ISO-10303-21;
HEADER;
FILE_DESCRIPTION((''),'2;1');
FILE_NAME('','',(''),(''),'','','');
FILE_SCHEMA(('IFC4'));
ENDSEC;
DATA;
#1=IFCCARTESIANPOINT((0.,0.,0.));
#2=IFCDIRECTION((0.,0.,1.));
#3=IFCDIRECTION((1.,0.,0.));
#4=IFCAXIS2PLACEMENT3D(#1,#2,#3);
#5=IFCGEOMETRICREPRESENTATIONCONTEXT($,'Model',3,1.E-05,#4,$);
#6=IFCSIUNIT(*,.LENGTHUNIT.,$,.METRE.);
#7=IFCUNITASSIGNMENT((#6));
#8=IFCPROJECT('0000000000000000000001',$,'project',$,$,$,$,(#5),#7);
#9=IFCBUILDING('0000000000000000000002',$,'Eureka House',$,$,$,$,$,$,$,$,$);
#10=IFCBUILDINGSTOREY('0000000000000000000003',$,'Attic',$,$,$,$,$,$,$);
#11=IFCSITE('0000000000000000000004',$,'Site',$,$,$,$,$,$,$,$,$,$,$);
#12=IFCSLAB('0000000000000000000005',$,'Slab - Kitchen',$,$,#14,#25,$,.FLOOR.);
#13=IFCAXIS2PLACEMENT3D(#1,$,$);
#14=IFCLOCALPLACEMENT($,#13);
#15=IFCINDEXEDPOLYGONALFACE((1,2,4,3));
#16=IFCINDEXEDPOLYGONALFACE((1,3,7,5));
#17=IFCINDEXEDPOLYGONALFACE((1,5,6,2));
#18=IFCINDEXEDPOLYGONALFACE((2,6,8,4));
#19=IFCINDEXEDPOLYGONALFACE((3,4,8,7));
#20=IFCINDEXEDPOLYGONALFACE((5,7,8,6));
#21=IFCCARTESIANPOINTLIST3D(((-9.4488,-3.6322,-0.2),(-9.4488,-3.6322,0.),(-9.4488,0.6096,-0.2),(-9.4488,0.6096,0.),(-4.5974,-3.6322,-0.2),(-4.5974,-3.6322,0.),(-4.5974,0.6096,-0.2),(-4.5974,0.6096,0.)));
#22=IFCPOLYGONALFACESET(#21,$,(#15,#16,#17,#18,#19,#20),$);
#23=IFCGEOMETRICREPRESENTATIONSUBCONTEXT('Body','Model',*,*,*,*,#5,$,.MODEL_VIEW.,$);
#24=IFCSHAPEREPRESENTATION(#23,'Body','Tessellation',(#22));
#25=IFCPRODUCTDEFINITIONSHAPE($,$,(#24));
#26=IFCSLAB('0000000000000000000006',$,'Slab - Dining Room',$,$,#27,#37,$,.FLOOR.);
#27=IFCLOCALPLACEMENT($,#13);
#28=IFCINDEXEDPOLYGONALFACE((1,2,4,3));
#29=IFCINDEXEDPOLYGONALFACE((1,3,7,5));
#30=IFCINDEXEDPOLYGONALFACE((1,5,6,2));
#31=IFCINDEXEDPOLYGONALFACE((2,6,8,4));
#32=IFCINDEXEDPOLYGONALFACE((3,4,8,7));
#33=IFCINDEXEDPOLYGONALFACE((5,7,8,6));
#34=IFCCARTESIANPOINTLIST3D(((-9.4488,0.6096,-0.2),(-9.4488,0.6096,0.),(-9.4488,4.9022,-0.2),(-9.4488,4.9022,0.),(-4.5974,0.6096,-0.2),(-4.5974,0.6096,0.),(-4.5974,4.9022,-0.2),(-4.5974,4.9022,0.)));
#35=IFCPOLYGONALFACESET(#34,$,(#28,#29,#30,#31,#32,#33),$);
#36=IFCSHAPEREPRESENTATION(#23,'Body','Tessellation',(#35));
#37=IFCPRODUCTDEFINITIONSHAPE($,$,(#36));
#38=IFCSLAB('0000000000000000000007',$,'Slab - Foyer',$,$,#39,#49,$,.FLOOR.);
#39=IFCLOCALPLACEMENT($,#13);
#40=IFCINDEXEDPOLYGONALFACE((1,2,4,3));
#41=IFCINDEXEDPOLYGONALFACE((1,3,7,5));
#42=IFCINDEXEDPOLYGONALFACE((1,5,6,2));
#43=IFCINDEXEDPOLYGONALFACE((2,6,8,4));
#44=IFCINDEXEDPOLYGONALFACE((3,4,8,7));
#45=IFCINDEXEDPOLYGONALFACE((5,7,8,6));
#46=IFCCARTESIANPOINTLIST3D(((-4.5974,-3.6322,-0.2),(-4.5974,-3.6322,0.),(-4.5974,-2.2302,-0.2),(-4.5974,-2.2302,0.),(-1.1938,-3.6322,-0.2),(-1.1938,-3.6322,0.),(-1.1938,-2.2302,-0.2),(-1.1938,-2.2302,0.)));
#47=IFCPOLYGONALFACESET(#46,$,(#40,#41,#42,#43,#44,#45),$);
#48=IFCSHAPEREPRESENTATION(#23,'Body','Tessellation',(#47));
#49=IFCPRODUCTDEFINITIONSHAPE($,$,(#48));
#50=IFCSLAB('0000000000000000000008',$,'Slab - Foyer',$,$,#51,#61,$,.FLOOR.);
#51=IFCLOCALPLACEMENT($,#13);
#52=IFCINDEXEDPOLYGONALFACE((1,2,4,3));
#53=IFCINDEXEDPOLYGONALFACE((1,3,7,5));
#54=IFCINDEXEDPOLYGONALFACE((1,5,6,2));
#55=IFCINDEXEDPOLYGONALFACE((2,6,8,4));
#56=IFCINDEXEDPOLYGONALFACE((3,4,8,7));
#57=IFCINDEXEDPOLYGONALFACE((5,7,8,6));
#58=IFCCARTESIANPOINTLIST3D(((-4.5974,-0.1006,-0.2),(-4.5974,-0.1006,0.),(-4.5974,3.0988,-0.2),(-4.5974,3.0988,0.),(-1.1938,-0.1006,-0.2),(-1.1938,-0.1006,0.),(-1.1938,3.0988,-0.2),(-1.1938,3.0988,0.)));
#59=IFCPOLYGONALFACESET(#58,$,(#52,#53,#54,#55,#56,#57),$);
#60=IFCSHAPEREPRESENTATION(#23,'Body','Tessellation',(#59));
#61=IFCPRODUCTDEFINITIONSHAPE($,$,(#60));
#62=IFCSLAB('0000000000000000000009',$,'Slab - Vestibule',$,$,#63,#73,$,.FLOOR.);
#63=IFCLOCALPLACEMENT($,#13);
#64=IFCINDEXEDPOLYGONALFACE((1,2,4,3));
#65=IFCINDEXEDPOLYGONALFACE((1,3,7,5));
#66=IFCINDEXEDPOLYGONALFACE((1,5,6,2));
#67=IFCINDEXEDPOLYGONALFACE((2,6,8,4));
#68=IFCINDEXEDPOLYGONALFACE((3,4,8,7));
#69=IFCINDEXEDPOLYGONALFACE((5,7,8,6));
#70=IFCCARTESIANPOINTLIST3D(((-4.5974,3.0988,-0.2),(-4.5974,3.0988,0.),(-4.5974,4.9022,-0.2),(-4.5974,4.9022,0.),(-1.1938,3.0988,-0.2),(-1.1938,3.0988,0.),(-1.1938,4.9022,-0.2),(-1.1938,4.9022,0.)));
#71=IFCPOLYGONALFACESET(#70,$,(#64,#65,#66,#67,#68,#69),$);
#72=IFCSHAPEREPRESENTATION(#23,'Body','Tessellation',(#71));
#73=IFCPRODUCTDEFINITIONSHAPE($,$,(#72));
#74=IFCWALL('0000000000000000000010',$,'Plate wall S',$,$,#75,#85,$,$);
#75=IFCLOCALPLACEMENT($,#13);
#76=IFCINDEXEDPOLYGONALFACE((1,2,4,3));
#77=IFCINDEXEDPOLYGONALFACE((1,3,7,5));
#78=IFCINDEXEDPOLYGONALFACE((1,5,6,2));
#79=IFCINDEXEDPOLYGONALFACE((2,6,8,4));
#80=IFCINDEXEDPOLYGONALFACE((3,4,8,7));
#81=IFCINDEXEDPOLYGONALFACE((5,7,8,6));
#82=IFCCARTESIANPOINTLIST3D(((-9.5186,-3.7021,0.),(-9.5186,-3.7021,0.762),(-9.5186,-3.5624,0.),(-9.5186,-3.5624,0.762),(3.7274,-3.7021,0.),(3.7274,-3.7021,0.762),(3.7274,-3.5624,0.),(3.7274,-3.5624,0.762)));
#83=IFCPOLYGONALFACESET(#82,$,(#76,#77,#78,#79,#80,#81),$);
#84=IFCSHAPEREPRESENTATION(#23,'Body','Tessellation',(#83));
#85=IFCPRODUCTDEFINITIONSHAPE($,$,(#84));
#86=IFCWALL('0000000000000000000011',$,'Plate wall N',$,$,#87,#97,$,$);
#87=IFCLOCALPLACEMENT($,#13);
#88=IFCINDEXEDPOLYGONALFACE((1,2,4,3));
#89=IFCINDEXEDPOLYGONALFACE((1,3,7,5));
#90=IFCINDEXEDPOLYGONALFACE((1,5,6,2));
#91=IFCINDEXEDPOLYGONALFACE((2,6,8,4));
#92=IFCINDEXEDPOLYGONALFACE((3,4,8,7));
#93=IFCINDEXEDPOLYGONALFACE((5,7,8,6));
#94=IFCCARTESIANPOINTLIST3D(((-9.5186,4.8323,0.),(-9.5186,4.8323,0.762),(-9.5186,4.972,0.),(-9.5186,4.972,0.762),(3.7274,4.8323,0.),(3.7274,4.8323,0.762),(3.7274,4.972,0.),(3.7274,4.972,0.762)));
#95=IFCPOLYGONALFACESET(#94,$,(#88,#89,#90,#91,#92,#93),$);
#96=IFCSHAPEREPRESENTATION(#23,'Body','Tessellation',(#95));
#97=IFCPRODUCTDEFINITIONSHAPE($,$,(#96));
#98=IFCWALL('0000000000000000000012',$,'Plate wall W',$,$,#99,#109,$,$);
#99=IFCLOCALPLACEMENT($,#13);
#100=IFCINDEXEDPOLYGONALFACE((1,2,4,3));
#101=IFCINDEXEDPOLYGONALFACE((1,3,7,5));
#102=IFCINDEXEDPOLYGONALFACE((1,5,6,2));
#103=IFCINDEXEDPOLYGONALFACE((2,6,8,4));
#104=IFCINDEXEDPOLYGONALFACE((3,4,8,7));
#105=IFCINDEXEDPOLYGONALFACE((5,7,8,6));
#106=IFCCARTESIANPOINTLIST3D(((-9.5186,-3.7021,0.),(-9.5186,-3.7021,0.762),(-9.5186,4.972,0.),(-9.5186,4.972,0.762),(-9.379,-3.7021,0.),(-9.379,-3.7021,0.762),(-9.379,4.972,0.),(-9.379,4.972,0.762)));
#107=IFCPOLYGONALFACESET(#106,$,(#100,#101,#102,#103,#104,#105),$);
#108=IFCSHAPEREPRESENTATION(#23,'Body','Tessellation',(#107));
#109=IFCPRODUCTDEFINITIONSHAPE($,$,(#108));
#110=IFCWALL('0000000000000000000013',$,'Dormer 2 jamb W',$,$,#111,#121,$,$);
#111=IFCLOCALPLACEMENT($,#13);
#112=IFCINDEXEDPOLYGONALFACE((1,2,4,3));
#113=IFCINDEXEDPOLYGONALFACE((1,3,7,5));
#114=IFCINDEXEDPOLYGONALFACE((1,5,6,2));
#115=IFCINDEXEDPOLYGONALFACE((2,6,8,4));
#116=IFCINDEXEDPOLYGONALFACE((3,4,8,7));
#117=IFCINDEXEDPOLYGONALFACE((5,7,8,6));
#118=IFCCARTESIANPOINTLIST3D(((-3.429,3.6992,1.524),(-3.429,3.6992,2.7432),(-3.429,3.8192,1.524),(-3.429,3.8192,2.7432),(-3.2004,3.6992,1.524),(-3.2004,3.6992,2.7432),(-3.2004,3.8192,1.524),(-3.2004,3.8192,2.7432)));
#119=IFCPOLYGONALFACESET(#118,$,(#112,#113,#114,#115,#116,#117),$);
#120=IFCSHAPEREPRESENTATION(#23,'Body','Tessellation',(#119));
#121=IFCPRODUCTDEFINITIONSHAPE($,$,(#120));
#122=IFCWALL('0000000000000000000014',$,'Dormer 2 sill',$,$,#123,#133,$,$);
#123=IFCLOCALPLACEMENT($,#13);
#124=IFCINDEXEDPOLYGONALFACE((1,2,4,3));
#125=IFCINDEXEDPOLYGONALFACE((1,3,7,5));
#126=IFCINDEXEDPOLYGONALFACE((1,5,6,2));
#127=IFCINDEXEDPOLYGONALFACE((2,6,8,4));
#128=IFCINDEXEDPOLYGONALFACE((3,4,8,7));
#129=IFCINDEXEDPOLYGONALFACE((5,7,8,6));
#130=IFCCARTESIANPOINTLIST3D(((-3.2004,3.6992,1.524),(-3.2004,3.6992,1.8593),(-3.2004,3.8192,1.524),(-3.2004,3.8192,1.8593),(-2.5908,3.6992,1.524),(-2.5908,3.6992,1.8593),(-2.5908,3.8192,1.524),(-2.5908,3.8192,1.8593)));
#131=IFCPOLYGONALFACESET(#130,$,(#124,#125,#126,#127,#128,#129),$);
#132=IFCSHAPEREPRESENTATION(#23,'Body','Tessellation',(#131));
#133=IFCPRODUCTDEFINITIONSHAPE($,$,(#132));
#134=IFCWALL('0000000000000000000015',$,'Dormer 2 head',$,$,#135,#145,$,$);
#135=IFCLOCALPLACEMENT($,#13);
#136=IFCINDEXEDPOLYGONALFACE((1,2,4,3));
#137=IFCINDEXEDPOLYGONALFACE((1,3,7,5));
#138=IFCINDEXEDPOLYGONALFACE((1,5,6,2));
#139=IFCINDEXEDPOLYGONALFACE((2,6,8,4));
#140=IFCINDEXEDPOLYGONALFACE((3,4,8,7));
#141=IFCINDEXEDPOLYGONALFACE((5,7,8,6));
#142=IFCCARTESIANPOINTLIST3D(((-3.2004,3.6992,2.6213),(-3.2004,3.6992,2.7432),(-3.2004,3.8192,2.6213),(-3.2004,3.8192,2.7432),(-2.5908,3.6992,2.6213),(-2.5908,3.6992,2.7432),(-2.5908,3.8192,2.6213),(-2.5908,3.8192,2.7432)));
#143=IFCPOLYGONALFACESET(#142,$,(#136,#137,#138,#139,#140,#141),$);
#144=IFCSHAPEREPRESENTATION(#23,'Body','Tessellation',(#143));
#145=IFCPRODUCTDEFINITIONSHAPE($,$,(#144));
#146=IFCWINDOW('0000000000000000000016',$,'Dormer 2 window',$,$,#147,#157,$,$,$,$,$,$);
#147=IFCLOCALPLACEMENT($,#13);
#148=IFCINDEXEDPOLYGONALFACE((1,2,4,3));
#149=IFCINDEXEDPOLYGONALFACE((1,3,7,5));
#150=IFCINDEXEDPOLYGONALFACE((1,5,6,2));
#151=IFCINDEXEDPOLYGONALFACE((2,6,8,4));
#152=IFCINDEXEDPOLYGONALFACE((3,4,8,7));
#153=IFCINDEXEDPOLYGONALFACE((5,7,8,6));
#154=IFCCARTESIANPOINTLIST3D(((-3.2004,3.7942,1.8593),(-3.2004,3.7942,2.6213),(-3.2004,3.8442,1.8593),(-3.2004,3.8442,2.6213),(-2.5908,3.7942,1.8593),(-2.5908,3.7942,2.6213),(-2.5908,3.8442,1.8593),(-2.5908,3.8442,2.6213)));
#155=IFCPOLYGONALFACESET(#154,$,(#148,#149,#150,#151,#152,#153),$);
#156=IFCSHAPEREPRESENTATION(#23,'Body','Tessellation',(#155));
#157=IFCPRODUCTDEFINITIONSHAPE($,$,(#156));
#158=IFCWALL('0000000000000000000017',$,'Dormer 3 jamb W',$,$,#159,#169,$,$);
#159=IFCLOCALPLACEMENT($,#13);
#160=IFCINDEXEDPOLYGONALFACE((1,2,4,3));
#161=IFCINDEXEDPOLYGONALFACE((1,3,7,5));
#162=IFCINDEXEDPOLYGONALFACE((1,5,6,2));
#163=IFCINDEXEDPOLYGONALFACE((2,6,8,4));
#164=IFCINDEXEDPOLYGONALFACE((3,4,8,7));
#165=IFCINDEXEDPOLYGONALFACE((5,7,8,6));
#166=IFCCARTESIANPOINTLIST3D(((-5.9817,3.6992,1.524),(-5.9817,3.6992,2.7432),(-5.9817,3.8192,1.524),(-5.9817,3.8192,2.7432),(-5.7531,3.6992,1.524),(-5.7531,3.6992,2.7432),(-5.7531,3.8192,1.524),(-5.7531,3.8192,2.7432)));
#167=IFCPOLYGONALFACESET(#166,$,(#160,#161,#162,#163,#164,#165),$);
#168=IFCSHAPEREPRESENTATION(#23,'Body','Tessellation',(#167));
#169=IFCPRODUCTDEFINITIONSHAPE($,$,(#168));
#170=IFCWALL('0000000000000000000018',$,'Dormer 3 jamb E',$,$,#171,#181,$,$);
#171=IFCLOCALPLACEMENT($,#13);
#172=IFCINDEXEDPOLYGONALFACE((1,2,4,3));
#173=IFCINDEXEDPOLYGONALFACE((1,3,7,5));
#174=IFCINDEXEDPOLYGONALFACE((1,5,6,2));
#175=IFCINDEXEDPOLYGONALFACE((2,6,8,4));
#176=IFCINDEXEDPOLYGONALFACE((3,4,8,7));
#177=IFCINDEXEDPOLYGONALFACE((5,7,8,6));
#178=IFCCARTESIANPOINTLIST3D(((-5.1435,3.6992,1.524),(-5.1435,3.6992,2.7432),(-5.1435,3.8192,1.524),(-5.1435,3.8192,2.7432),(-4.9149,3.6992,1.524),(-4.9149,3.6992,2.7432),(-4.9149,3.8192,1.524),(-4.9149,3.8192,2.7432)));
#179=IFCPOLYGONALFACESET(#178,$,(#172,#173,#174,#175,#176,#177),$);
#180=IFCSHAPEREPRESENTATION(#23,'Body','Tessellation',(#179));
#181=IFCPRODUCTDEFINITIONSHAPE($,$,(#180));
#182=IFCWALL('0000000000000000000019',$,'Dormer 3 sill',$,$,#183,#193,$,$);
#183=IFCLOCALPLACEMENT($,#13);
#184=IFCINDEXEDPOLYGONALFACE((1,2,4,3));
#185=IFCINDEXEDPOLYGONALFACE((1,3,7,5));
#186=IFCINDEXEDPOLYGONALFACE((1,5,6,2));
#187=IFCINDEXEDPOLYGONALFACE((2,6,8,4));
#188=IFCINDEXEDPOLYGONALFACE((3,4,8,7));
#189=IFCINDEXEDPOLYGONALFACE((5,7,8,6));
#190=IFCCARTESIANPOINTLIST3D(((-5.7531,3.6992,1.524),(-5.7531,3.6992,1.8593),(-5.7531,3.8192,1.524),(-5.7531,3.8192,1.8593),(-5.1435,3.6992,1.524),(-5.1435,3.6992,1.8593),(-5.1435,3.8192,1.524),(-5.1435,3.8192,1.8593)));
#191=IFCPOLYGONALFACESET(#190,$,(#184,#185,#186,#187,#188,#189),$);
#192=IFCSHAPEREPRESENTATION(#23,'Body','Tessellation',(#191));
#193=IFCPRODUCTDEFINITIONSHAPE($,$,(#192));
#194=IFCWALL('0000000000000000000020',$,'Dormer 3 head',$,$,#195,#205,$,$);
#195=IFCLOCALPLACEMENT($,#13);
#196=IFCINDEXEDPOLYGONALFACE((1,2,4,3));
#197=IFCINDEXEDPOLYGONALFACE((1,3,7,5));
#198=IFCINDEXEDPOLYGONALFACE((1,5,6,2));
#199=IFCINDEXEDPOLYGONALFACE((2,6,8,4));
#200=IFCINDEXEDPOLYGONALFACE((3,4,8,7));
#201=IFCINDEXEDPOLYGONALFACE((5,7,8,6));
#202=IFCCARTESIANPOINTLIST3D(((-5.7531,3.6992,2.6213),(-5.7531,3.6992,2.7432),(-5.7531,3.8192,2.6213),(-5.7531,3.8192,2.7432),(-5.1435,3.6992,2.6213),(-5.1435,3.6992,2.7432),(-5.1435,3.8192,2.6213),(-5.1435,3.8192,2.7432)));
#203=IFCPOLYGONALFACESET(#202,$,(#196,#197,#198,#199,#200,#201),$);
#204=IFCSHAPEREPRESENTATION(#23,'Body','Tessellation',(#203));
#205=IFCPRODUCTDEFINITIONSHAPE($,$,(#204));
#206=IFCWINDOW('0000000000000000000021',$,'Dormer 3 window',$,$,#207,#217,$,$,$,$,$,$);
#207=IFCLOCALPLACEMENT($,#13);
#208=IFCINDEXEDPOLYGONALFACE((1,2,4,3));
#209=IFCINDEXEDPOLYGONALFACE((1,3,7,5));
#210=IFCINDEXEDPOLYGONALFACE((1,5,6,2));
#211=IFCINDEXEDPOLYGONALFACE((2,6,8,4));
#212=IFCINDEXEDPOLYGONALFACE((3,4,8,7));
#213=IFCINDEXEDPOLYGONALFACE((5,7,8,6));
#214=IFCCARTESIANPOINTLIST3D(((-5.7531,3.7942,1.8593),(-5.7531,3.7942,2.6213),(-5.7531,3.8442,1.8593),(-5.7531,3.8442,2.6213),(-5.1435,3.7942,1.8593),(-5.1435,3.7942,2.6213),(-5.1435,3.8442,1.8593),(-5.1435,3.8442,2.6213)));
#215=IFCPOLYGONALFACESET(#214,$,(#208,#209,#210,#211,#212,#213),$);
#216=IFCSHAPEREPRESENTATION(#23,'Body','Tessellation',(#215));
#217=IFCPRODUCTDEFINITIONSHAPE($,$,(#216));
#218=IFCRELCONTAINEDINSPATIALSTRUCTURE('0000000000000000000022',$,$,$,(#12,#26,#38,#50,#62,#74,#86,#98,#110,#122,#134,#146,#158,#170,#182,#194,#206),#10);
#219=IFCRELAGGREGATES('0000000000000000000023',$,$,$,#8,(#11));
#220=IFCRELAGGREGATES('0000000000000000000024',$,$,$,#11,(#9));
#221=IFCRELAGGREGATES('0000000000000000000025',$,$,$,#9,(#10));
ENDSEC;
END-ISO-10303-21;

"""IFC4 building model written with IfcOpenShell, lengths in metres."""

from ifc_helpers import new_model, si_unit, frame, origin, origin_with_axes, origin_2d, place, context, subcontext, project, spatial, rectangle, extrude, element, save


model = new_model("IFC4")

# Units and contexts
model_context = context("Model", 3, precision=1e-05, world=origin_with_axes())
body_context = subcontext(model_context, "Body", "Model", "MODEL_VIEW")
ifc_project = project(units=[si_unit("LENGTHUNIT", "METRE")], contexts=[model_context])

# Site, building, storey
site = spatial("IfcSite", under=ifc_project, Name="Site")
building = spatial("IfcBuilding", under=site, Name="Eureka House")
storey = spatial("IfcBuildingStorey", under=building, Name="Attic")

# Slabs
slab_1_placement = place(None, frame((-7.0231, -1.5113, -0.2), z_axis=(0.0, 0.0, 1.0), x_axis=(1.0, 0.0, 0.0)))
element("IfcSlab", 1, at=slab_1_placement, inside=storey, Name="Slab - Kitchen", PredefinedType="FLOOR", context=body_context, shape_type="SweptSolid", body=[
    extrude(rectangle(XDim=4.8514, YDim=4.2418, at=origin_2d()), origin(), (0.0, 0.0, 1.0), 0.2),
])
slab_2_placement = place(None, frame((-7.0231, 2.7559, -0.2), z_axis=(0.0, 0.0, 1.0), x_axis=(1.0, 0.0, 0.0)))
element("IfcSlab", 2, at=slab_2_placement, inside=storey, Name="Slab - Dining Room", PredefinedType="FLOOR", context=body_context, shape_type="SweptSolid", body=[
    extrude(rectangle(XDim=4.8514, YDim=4.2926, at=origin_2d()), origin(), (0.0, 0.0, 1.0), 0.2),
])
slab_3_placement = place(None, frame((-2.8956, -2.9312, -0.2), z_axis=(0.0, 0.0, 1.0), x_axis=(1.0, 0.0, 0.0)))
element("IfcSlab", 3, at=slab_3_placement, inside=storey, Name="Slab - Foyer", PredefinedType="FLOOR", context=body_context, shape_type="SweptSolid", body=[
    extrude(rectangle(XDim=3.4036, YDim=1.402, at=origin_2d()), origin(), (0.0, 0.0, 1.0), 0.2),
])
slab_4_placement = place(None, frame((-2.8956, 1.4991, -0.2), z_axis=(0.0, 0.0, 1.0), x_axis=(1.0, 0.0, 0.0)))
element("IfcSlab", 4, at=slab_4_placement, inside=storey, Name="Slab - Foyer", PredefinedType="FLOOR", context=body_context, shape_type="SweptSolid", body=[
    extrude(rectangle(XDim=3.4036, YDim=3.1994, at=origin_2d()), origin(), (0.0, 0.0, 1.0), 0.2),
])
slab_5_placement = place(None, frame((-2.8956, 4.0005, -0.2), z_axis=(0.0, 0.0, 1.0), x_axis=(1.0, 0.0, 0.0)))
element("IfcSlab", 5, at=slab_5_placement, inside=storey, Name="Slab - Vestibule", PredefinedType="FLOOR", context=body_context, shape_type="SweptSolid", body=[
    extrude(rectangle(XDim=3.4036, YDim=1.8034, at=origin_2d()), origin(), (0.0, 0.0, 1.0), 0.2),
])

# Walls
for number, where, z_axis, x_axis, name in (
    (6, (-2.8956, -3.6322, 0.0), (0.0, 0.0, 1.0), (1.0, 0.0, 0.0), "Plate wall S"),
    (7, (-2.8956, 4.9022, 0.0), (0.0, 0.0, 1.0), (1.0, 0.0, 0.0), "Plate wall N"),
):
    element("IfcWall", number, at=place(None, frame(where, z_axis=z_axis, x_axis=x_axis)), inside=storey, Name=name, context=body_context, shape_type="SweptSolid", body=[
        extrude(rectangle(XDim=13.2461, YDim=0.1397, at=origin_2d()), origin(), (0.0, 0.0, 1.0), 0.762),
    ])
wall_1_placement = place(None, frame((-9.4488, 0.635, 0.0), z_axis=(0.0, 0.0, 1.0), x_axis=(1.0, 0.0, 0.0)))
element("IfcWall", 8, at=wall_1_placement, inside=storey, Name="Plate wall W", context=body_context, shape_type="SweptSolid", body=[
    extrude(rectangle(XDim=0.1397, YDim=8.6741, at=origin_2d()), origin(), (0.0, 0.0, 1.0), 0.762),
])
wall_2_placement = place(None, frame((-3.3147, 3.7592, 1.524), z_axis=(0.0, 0.0, 1.0), x_axis=(1.0, 0.0, 0.0)))
element("IfcWall", 9, at=wall_2_placement, inside=storey, Name="Dormer 2 jamb W", context=body_context, shape_type="SweptSolid", body=[
    extrude(rectangle(XDim=0.2286, YDim=0.12, at=origin_2d()), origin(), (0.0, 0.0, 1.0), 1.2192),
])
wall_3_placement = place(None, frame((-2.8956, 3.7592, 1.524), z_axis=(0.0, 0.0, 1.0), x_axis=(1.0, 0.0, 0.0)))
element("IfcWall", 10, at=wall_3_placement, inside=storey, Name="Dormer 2 sill", context=body_context, shape_type="SweptSolid", body=[
    extrude(rectangle(XDim=0.6096, YDim=0.12, at=origin_2d()), origin(), (0.0, 0.0, 1.0), 0.3353),
])
wall_4_placement = place(None, frame((-2.8956, 3.7592, 2.6213), z_axis=(0.0, 0.0, 1.0), x_axis=(1.0, 0.0, 0.0)))
element("IfcWall", 11, at=wall_4_placement, inside=storey, Name="Dormer 2 head", context=body_context, shape_type="SweptSolid", body=[
    extrude(rectangle(XDim=0.6096, YDim=0.12, at=origin_2d()), origin(), (0.0, 0.0, 1.0), 0.1219),
])

# Window
window_1_placement = place(None, frame((-2.8956, 3.8192, 1.8593), z_axis=(0.0, 0.0, 1.0), x_axis=(1.0, 0.0, 0.0)))
element("IfcWindow", 12, at=window_1_placement, inside=storey, Name="Dormer 2 window", context=body_context, shape_type="SweptSolid", body=[
    extrude(rectangle(XDim=0.6096, YDim=0.05, at=origin_2d()), origin(), (0.0, 0.0, 1.0), 0.762),
])

# Walls
for number, where, z_axis, x_axis, name in (
    (13, (-5.8674, 3.7592, 1.524), (0.0, 0.0, 1.0), (1.0, 0.0, 0.0), "Dormer 3 jamb W"),
    (14, (-5.0292, 3.7592, 1.524), (0.0, 0.0, 1.0), (1.0, 0.0, 0.0), "Dormer 3 jamb E"),
):
    element("IfcWall", number, at=place(None, frame(where, z_axis=z_axis, x_axis=x_axis)), inside=storey, Name=name, context=body_context, shape_type="SweptSolid", body=[
        extrude(rectangle(XDim=0.2286, YDim=0.12, at=origin_2d()), origin(), (0.0, 0.0, 1.0), 1.2192),
    ])
wall_5_placement = place(None, frame((-5.4483, 3.7592, 1.524), z_axis=(0.0, 0.0, 1.0), x_axis=(1.0, 0.0, 0.0)))
element("IfcWall", 15, at=wall_5_placement, inside=storey, Name="Dormer 3 sill", context=body_context, shape_type="SweptSolid", body=[
    extrude(rectangle(XDim=0.6096, YDim=0.12, at=origin_2d()), origin(), (0.0, 0.0, 1.0), 0.3353),
])
wall_6_placement = place(None, frame((-5.4483, 3.7592, 2.6213), z_axis=(0.0, 0.0, 1.0), x_axis=(1.0, 0.0, 0.0)))
element("IfcWall", 16, at=wall_6_placement, inside=storey, Name="Dormer 3 head", context=body_context, shape_type="SweptSolid", body=[
    extrude(rectangle(XDim=0.6096, YDim=0.12, at=origin_2d()), origin(), (0.0, 0.0, 1.0), 0.1219),
])

# Window
window_2_placement = place(None, frame((-5.4483, 3.8192, 1.8593), z_axis=(0.0, 0.0, 1.0), x_axis=(1.0, 0.0, 0.0)))
element("IfcWindow", 17, at=window_2_placement, inside=storey, Name="Dormer 3 window", context=body_context, shape_type="SweptSolid", body=[
    extrude(rectangle(XDim=0.6096, YDim=0.05, at=origin_2d()), origin(), (0.0, 0.0, 1.0), 0.762),
])

save(model, "model.ifc")
